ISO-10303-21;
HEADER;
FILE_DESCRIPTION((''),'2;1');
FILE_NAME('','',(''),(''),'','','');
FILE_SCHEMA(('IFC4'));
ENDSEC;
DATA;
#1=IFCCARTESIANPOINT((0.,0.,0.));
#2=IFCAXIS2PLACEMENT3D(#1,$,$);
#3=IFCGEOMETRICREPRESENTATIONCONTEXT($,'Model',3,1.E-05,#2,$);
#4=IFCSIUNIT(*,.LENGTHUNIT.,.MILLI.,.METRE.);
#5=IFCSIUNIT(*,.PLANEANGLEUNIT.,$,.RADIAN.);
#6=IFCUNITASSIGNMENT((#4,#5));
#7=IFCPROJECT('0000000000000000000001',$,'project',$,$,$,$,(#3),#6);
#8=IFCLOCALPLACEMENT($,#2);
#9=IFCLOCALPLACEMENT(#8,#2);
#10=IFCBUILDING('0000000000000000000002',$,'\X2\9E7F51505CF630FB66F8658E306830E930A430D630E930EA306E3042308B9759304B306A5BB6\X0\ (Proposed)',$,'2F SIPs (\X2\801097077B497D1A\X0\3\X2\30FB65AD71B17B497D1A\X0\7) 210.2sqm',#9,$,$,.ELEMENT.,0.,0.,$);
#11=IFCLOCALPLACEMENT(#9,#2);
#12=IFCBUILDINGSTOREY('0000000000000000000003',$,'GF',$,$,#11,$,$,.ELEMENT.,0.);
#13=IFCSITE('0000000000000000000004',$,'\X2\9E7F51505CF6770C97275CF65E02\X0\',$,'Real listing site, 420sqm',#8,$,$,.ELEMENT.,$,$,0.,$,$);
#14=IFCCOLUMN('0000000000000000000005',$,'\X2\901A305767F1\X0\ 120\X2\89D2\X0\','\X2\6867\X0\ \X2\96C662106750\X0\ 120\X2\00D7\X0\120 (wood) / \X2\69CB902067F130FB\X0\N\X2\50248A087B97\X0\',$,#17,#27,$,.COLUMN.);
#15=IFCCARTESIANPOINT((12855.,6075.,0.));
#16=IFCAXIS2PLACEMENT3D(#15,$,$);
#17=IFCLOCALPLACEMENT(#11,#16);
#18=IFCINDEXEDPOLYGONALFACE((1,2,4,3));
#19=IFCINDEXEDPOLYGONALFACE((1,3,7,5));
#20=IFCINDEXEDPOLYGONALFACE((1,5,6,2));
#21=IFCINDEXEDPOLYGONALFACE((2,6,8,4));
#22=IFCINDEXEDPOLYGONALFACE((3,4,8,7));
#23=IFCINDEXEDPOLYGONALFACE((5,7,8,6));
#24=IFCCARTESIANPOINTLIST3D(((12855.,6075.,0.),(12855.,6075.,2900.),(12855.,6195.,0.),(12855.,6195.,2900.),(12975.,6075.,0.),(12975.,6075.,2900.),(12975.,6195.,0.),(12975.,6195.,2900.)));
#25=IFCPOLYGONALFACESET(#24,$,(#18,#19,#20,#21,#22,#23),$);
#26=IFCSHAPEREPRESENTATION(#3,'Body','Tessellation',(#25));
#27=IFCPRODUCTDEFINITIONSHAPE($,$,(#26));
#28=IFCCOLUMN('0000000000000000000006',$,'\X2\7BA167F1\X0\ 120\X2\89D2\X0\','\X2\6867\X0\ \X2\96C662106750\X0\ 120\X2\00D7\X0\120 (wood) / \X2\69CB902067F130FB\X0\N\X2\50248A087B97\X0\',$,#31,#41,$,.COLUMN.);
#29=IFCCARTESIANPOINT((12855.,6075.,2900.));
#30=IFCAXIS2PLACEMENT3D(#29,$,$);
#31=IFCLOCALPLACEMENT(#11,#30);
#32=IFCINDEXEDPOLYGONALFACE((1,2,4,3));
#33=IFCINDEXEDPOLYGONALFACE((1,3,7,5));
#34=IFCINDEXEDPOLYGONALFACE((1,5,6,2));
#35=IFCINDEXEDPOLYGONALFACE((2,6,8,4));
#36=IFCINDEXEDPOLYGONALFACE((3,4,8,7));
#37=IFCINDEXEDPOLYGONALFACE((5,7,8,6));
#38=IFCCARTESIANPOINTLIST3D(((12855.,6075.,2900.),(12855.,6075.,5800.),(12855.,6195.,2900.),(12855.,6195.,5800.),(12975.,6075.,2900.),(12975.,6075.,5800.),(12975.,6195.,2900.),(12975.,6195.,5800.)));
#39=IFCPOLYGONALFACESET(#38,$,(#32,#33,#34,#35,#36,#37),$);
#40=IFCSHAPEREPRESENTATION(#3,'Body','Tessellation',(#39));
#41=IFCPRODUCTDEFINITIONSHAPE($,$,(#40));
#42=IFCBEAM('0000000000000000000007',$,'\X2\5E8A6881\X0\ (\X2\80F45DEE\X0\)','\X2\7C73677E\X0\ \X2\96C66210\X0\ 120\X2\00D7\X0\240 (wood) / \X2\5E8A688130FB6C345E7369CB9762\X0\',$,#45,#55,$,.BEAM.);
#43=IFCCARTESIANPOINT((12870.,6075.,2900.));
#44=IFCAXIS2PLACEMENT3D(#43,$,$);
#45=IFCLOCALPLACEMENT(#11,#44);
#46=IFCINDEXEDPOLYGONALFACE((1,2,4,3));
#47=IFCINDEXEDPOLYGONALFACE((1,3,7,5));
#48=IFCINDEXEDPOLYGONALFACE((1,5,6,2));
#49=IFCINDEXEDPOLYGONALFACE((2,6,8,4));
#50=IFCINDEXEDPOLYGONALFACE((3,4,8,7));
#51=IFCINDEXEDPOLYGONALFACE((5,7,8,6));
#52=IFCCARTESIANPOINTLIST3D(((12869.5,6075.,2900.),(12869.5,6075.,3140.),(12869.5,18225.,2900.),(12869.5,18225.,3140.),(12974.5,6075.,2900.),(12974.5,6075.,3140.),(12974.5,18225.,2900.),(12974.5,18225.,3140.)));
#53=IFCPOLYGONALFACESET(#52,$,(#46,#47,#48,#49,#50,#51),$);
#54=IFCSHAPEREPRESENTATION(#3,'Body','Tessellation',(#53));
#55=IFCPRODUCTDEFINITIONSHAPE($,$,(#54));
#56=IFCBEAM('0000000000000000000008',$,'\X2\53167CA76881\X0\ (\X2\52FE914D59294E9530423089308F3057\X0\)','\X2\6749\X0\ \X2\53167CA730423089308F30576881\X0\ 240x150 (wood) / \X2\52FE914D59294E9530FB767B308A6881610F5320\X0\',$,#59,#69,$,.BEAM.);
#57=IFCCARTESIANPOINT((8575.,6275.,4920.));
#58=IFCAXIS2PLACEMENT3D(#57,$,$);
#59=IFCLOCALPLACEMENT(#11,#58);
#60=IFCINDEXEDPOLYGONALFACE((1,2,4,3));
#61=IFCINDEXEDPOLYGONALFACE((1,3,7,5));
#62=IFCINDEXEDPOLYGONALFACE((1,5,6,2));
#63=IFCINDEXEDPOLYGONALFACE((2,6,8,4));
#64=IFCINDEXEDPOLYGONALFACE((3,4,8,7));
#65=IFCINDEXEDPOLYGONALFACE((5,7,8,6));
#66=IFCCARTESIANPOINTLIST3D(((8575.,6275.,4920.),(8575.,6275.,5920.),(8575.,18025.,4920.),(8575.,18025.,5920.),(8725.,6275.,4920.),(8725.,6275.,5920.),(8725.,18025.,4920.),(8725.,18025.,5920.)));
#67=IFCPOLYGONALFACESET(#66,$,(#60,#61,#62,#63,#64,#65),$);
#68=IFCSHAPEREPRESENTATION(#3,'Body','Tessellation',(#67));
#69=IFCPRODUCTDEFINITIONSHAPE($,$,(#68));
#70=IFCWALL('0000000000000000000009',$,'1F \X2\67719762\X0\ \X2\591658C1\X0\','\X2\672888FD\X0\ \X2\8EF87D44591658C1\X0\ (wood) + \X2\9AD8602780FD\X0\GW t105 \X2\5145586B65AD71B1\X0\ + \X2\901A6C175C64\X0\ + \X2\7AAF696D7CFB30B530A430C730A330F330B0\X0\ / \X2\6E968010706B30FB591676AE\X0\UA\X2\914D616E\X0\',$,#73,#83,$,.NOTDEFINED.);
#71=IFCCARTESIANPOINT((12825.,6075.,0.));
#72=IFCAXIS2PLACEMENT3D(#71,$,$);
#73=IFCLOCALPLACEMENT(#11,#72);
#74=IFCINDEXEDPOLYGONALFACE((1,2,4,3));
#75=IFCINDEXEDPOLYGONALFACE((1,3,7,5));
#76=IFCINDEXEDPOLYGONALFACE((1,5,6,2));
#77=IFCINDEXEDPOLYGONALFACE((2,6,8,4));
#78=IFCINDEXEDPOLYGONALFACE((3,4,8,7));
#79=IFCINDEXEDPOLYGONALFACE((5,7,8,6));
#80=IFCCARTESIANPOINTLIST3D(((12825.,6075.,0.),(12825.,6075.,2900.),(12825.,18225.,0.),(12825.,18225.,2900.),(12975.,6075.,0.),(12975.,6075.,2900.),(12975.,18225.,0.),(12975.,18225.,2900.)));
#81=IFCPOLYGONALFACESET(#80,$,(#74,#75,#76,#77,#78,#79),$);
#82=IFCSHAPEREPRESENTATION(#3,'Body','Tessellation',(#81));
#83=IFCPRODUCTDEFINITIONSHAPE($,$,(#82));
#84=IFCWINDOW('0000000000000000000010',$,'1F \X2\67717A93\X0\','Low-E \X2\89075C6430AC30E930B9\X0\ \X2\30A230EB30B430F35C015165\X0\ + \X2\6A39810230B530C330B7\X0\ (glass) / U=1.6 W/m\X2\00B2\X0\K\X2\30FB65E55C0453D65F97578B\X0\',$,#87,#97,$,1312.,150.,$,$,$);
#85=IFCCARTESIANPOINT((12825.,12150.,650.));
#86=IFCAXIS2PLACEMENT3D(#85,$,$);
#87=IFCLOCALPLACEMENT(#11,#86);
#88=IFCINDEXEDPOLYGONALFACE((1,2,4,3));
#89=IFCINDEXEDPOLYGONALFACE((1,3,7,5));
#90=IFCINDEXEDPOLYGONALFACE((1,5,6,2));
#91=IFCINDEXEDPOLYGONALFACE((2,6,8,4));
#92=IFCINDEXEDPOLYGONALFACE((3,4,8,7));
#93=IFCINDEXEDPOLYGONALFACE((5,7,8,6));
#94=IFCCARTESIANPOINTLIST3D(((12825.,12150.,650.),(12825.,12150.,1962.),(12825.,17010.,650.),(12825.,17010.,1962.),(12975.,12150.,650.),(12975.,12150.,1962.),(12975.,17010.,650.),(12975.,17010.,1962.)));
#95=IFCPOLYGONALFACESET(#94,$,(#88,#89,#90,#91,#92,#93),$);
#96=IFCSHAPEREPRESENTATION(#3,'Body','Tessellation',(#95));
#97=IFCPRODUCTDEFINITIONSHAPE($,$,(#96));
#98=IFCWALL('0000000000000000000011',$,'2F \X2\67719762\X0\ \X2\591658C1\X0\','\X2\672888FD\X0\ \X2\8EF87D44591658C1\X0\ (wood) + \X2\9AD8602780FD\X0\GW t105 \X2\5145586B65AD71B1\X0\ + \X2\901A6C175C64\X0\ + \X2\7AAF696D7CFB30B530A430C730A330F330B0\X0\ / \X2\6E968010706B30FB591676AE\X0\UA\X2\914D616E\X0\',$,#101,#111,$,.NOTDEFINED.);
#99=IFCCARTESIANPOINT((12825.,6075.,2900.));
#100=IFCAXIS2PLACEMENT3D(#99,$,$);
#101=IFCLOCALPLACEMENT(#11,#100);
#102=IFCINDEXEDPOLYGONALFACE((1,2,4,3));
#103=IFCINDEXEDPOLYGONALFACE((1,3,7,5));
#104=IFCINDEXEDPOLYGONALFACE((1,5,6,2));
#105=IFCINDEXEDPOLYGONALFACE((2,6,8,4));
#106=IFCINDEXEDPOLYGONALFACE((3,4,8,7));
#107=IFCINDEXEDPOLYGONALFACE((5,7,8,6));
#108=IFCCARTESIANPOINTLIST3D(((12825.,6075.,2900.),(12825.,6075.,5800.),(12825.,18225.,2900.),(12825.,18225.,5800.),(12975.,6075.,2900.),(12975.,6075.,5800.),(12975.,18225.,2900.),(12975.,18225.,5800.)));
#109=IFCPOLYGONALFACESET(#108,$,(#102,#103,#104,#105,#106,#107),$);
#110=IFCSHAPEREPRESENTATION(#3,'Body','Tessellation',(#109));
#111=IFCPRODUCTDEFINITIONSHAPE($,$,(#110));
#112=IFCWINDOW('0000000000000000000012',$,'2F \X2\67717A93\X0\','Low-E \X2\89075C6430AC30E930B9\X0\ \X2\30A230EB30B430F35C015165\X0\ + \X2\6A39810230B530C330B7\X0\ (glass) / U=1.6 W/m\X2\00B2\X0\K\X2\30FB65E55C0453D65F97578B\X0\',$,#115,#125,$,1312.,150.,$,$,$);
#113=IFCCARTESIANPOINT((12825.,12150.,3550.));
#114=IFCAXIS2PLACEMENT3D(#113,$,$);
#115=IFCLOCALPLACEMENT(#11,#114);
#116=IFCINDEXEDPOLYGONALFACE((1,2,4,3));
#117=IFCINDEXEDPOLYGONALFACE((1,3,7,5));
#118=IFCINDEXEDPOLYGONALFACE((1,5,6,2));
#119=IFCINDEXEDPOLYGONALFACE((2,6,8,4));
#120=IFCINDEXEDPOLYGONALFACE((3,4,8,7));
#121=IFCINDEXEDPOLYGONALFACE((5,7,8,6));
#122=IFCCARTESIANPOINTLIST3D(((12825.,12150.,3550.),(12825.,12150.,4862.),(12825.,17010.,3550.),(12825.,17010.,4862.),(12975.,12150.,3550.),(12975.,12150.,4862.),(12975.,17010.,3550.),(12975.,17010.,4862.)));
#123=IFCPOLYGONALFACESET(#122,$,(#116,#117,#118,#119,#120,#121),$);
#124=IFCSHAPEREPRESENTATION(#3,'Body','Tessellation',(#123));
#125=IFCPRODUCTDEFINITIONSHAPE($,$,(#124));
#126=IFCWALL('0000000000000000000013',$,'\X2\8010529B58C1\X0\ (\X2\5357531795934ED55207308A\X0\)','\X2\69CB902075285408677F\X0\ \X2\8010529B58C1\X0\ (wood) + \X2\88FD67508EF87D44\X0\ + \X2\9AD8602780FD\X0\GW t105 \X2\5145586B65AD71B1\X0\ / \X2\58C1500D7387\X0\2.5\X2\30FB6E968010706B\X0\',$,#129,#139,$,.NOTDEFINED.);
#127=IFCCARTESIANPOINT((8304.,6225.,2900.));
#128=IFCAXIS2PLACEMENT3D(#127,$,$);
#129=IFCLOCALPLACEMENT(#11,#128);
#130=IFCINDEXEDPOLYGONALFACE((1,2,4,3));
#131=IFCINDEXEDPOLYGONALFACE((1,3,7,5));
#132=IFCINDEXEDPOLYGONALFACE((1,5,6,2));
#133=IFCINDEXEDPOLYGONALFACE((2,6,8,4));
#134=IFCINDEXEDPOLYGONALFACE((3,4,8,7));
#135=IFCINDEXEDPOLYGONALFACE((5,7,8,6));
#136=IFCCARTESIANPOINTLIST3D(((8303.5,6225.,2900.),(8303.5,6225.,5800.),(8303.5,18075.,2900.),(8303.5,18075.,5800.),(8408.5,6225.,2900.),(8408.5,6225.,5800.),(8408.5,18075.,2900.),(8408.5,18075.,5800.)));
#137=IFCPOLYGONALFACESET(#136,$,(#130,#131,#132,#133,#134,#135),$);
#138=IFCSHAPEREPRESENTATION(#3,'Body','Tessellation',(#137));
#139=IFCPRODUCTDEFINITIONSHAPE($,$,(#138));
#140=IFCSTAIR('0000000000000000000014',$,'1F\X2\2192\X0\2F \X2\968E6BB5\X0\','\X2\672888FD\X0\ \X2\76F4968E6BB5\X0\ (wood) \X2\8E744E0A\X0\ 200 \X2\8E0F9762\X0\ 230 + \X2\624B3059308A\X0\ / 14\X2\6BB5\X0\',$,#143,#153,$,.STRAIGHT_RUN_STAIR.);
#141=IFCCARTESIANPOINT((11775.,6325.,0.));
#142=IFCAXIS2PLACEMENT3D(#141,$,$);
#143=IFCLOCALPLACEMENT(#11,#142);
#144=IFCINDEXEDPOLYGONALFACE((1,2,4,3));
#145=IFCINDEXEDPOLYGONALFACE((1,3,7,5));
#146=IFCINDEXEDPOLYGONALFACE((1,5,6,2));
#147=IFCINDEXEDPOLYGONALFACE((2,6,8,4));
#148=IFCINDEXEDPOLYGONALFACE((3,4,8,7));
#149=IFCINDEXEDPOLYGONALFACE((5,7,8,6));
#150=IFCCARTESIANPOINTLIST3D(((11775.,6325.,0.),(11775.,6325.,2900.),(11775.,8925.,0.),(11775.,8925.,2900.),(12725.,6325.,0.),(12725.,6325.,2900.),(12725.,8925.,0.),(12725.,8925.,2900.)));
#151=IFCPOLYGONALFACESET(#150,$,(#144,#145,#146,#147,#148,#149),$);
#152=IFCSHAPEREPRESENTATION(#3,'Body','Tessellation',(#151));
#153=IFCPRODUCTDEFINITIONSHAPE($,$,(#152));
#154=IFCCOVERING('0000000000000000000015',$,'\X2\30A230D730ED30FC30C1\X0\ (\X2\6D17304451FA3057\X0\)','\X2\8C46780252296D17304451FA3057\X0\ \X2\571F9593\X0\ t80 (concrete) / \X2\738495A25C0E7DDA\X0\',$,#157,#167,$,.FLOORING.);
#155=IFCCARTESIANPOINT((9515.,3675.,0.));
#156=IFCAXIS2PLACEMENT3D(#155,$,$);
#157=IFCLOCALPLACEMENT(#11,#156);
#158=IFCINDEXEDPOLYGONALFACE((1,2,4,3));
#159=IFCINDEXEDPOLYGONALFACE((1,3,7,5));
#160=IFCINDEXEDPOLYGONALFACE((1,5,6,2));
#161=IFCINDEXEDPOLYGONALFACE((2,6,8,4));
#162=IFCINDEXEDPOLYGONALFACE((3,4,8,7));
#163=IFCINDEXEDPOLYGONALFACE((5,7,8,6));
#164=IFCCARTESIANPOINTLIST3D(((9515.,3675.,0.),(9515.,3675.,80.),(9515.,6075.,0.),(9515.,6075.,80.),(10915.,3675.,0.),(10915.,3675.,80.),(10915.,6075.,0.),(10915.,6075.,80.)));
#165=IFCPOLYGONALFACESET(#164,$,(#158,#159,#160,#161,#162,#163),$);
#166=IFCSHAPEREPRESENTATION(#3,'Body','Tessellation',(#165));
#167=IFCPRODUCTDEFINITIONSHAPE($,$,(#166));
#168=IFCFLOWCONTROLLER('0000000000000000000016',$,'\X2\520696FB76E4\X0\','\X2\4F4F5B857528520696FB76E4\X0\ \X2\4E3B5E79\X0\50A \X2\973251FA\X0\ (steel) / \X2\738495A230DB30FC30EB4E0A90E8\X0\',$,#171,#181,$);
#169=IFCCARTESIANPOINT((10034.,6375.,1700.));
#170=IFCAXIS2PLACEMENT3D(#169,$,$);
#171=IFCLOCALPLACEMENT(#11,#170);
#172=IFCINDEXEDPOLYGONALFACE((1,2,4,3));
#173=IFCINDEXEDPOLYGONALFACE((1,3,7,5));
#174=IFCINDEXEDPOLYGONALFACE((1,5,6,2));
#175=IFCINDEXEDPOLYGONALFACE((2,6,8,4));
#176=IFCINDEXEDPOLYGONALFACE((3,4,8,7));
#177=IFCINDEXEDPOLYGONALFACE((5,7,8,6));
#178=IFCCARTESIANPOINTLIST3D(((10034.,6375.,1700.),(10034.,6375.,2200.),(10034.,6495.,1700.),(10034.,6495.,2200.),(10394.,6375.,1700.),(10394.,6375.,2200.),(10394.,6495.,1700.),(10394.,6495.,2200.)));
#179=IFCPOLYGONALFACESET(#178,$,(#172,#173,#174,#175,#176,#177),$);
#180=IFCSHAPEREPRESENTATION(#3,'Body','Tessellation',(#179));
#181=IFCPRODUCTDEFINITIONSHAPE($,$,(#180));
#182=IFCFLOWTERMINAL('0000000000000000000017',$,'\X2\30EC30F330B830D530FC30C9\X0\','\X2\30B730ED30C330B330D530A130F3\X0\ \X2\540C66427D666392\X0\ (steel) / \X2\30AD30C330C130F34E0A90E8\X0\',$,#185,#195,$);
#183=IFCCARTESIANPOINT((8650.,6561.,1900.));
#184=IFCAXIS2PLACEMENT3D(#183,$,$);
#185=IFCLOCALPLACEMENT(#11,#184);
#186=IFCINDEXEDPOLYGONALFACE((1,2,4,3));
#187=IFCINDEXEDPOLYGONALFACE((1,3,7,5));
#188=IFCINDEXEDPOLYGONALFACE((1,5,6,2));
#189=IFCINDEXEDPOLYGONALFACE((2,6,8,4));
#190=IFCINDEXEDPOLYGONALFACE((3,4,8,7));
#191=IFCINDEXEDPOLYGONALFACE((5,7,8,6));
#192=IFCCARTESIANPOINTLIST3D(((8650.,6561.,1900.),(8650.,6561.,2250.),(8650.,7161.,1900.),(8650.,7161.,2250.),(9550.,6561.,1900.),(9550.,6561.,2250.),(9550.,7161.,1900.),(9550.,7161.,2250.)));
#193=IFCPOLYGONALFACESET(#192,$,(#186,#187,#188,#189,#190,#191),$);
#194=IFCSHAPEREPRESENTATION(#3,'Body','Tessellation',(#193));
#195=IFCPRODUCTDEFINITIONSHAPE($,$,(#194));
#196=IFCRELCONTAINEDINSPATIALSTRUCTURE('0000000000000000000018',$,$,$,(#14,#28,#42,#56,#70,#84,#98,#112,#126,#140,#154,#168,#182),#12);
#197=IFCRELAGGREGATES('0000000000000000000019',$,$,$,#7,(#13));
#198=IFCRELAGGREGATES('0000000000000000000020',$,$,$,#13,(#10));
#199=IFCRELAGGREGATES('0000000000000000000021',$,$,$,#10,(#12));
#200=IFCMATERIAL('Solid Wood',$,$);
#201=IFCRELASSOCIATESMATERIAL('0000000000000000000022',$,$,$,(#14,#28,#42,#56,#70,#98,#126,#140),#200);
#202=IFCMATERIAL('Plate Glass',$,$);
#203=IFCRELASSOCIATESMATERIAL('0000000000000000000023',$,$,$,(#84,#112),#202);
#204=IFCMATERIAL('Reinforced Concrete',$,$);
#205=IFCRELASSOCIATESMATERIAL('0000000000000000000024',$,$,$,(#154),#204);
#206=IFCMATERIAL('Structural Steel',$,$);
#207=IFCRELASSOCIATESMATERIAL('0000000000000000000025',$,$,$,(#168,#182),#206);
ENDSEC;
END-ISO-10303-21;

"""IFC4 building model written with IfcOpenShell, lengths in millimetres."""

from ifc_helpers import new_model, si_unit, frame, frame_2d, origin, place, context, project, spatial, rectangle, extrude, material, element, fill, save


model = new_model("IFC4")

# Units and contexts
model_context = context("Model", 3, precision=1e-05, world=origin())
ifc_project = project(units=[si_unit("LENGTHUNIT", "METRE", prefix="MILLI"), si_unit("PLANEANGLEUNIT", "RADIAN")], contexts=[model_context])

# Site, building, storey
site_placement = place(None, origin())
site = spatial("IfcSite", under=ifc_project, at=site_placement, Name="鹿児島県霧島市", ObjectType="Real listing site, 420sqm", CompositionType="ELEMENT", RefElevation=0.0)
building_placement = place(site_placement, origin())
building = spatial("IfcBuilding", under=site, at=building_placement, Name="鹿児島・書斎とライブラリのある静かな家 (Proposed)", ObjectType="2F SIPs (耐震等級3・断熱等級7) 210.2sqm", CompositionType="ELEMENT", ElevationOfRefHeight=0.0, ElevationOfTerrain=0.0)
storey_placement = place(building_placement, origin())
storey = spatial("IfcBuildingStorey", under=building, at=storey_placement, Name="GF", CompositionType="ELEMENT", Elevation=0.0)

# Columns
ifc_material_1 = material(Name="Solid Wood")
column_1_placement = place(storey_placement, frame((12855.0, 6075.0, 0.0)))
element("IfcColumn", 1, at=column_1_placement, inside=storey, material=ifc_material_1, Name="通し柱 120角", Description="桧 集成材 120×120 (wood) / 構造柱・N値計算", PredefinedType="COLUMN", context=model_context, shape_type="SweptSolid", body=[
    extrude(rectangle(XDim=120.0, YDim=120.0, at=frame_2d((60.0, 60.0))), frame((12855.0, 6075.0, 0.0)), (0.0, 0.0, 1.0), 2900.0),
])
column_2_placement = place(storey_placement, frame((12855.0, 6075.0, 2900.0)))
element("IfcColumn", 2, at=column_2_placement, inside=storey, material=ifc_material_1, Name="管柱 120角", Description="桧 集成材 120×120 (wood) / 構造柱・N値計算", PredefinedType="COLUMN", context=model_context, shape_type="SweptSolid", body=[
    extrude(rectangle(XDim=120.0, YDim=120.0, at=frame_2d((60.0, 60.0))), frame((12855.0, 6075.0, 2900.0)), (0.0, 0.0, 1.0), 2900.0),
])

# Beams
beam_1_placement = place(storey_placement, frame((12870.0, 6075.0, 2900.0)))
element("IfcBeam", 3, at=beam_1_placement, inside=storey, material=ifc_material_1, Name="床梁 (胴差)", Description="米松 集成 120×240 (wood) / 床梁・水平構面", PredefinedType="BEAM", context=model_context, shape_type="SweptSolid", body=[
    extrude(rectangle(XDim=105.0, YDim=12150.0, at=frame_2d((52.0, 6075.0))), frame((12870.0, 6075.0, 2900.0)), (0.0, 0.0, 1.0), 240.0),
])
beam_2_placement = place(storey_placement, frame((8575.0, 6275.0, 4920.0)))
element("IfcBeam", 4, at=beam_2_placement, inside=storey, material=ifc_material_1, Name="化粧梁 (勾配天井あらわし)", Description="杉 化粧あらわし梁 240x150 (wood) / 勾配天井・登り梁意匠", PredefinedType="BEAM", context=model_context, shape_type="SweptSolid", body=[
    extrude(rectangle(XDim=150.0, YDim=11750.0, at=frame_2d((75.0, 5875.0))), frame((8575.0, 6275.0, 4920.0)), (0.0, 0.0, 1.0), 1000.0),
])

# Wall, opening, window
wall_1_placement = place(storey_placement, frame((12825.0, 6075.0, 0.0)))
wall_1 = element("IfcWall", 5, at=wall_1_placement, inside=storey, material=ifc_material_1, Name="1F 東面 外壁", Description="木製 軸組外壁 (wood) + 高性能GW t105 充填断熱 + 通気層 + 窯業系サイディング / 準耐火・外皮UA配慮", PredefinedType="NOTDEFINED", context=model_context, shape_type="SweptSolid", body=[
    extrude(rectangle(XDim=150.0, YDim=12150.0, at=frame_2d((75.0, 6075.0))), frame((12825.0, 6075.0, 0.0)), (0.0, 0.0, 1.0), 2900.0),
])
opening_1_placement = place(storey_placement, frame((12825.0, 12150.0, 650.0)))
opening_1 = element("IfcOpeningElement", 6, at=opening_1_placement, cuts=wall_1, PredefinedType="NOTDEFINED", context=model_context, shape_type="SweptSolid", body=[
    extrude(rectangle(XDim=150.0, YDim=4860.0, at=frame_2d((75.0, 2430.0))), frame((12825.0, 12150.0, 650.0)), (0.0, 0.0, 1.0), 1312.0),
])
ifc_material_2 = material(Name="Plate Glass")
window_1_placement = place(storey_placement, frame((12825.0, 12150.0, 650.0)))
window_1 = element("IfcWindow", 7, at=window_1_placement, inside=storey, material=ifc_material_2, Name="1F 東窓", Description="Low-E 複層ガラス アルゴン封入 + 樹脂サッシ (glass) / U=1.6 W/m²K・日射取得型", OverallHeight=1312.0, OverallWidth=150.0, context=model_context, shape_type="SweptSolid", body=[
    extrude(rectangle(XDim=150.0, YDim=4860.0, at=frame_2d((75.0, 2430.0))), frame((12825.0, 12150.0, 650.0)), (0.0, 0.0, 1.0), 1312.0),
])
fill(opening_1, window_1)

# Wall, opening, window
wall_2_placement = place(storey_placement, frame((12825.0, 6075.0, 2900.0)))
wall_2 = element("IfcWall", 8, at=wall_2_placement, inside=storey, material=ifc_material_1, Name="2F 東面 外壁", Description="木製 軸組外壁 (wood) + 高性能GW t105 充填断熱 + 通気層 + 窯業系サイディング / 準耐火・外皮UA配慮", PredefinedType="NOTDEFINED", context=model_context, shape_type="SweptSolid", body=[
    extrude(rectangle(XDim=150.0, YDim=12150.0, at=frame_2d((75.0, 6075.0))), frame((12825.0, 6075.0, 2900.0)), (0.0, 0.0, 1.0), 2900.0),
])
opening_2_placement = place(storey_placement, frame((12825.0, 12150.0, 3550.0)))
opening_2 = element("IfcOpeningElement", 9, at=opening_2_placement, cuts=wall_2, PredefinedType="NOTDEFINED", context=model_context, shape_type="SweptSolid", body=[
    extrude(rectangle(XDim=150.0, YDim=4860.0, at=frame_2d((75.0, 2430.0))), frame((12825.0, 12150.0, 3550.0)), (0.0, 0.0, 1.0), 1312.0),
])
window_2_placement = place(storey_placement, frame((12825.0, 12150.0, 3550.0)))
window_2 = element("IfcWindow", 10, at=window_2_placement, inside=storey, material=ifc_material_2, Name="2F 東窓", Description="Low-E 複層ガラス アルゴン封入 + 樹脂サッシ (glass) / U=1.6 W/m²K・日射取得型", OverallHeight=1312.0, OverallWidth=150.0, context=model_context, shape_type="SweptSolid", body=[
    extrude(rectangle(XDim=150.0, YDim=4860.0, at=frame_2d((75.0, 2430.0))), frame((12825.0, 12150.0, 3550.0)), (0.0, 0.0, 1.0), 1312.0),
])
fill(opening_2, window_2)

# Wall
wall_3_placement = place(storey_placement, frame((8304.0, 6225.0, 2900.0)))
element("IfcWall", 11, at=wall_3_placement, inside=storey, material=ifc_material_1, Name="耐力壁 (南北間仕切り)", Description="構造用合板 耐力壁 (wood) + 製材軸組 + 高性能GW t105 充填断熱 / 壁倍率2.5・準耐火", PredefinedType="NOTDEFINED", context=model_context, shape_type="SweptSolid", body=[
    extrude(rectangle(XDim=105.0, YDim=11850.0, at=frame_2d((52.0, 5925.0))), frame((8304.0, 6225.0, 2900.0)), (0.0, 0.0, 1.0), 2900.0),
])

# Stair
stair_placement = place(storey_placement, frame((11775.0, 6325.0, 0.0)))
element("IfcStair", 12, at=stair_placement, inside=storey, material=ifc_material_1, Name="1F→2F 階段", Description="木製 直階段 (wood) 蹴上 200 踏面 230 + 手すり / 14段", PredefinedType="STRAIGHT_RUN_STAIR", context=model_context, shape_type="SweptSolid", body=[
    extrude(rectangle(XDim=950.0, YDim=2600.0, at=frame_2d((475.0, 1300.0))), frame((11775.0, 6325.0, 0.0)), (0.0, 0.0, 1.0), 2900.0),
])

# Covering
ifc_material_3 = material(Name="Reinforced Concrete")
covering_placement = place(storey_placement, frame((9515.0, 3675.0, 0.0)))
element("IfcCovering", 13, at=covering_placement, inside=storey, material=ifc_material_3, Name="アプローチ (洗い出し)", Description="豆砂利洗い出し 土間 t80 (concrete) / 玄関導線", PredefinedType="FLOORING", context=model_context, shape_type="SweptSolid", body=[
    extrude(rectangle(XDim=1400.0, YDim=2400.0, at=frame_2d((700.0, 1200.0))), frame((9515.0, 3675.0, 0.0)), (0.0, 0.0, 1.0), 80.0),
])

# Flow controller
ifc_material_4 = material(Name="Structural Steel")
flow_controller_placement = place(storey_placement, frame((10034.0, 6375.0, 1700.0)))
element("IfcFlowController", 14, at=flow_controller_placement, inside=storey, material=ifc_material_4, Name="分電盤", Description="住宅用分電盤 主幹50A 露出 (steel) / 玄関ホール上部", context=model_context, shape_type="SweptSolid", body=[
    extrude(rectangle(XDim=360.0, YDim=120.0, at=frame_2d((180.0, 60.0))), frame((10034.0, 6375.0, 1700.0)), (0.0, 0.0, 1.0), 500.0),
])

# Flow terminal
flow_terminal_1_placement = place(storey_placement, frame((8650.0, 6561.0, 1900.0)))
element("IfcFlowTerminal", 15, at=flow_terminal_1_placement, inside=storey, material=ifc_material_4, Name="レンジフード", Description="シロッコファン 同時給排 (steel) / キッチン上部", context=model_context, shape_type="SweptSolid", body=[
    extrude(rectangle(XDim=900.0, YDim=600.0, at=frame_2d((450.0, 300.0))), frame((8650.0, 6561.0, 1900.0)), (0.0, 0.0, 1.0), 350.0),
])

save(model, "model.ifc")
